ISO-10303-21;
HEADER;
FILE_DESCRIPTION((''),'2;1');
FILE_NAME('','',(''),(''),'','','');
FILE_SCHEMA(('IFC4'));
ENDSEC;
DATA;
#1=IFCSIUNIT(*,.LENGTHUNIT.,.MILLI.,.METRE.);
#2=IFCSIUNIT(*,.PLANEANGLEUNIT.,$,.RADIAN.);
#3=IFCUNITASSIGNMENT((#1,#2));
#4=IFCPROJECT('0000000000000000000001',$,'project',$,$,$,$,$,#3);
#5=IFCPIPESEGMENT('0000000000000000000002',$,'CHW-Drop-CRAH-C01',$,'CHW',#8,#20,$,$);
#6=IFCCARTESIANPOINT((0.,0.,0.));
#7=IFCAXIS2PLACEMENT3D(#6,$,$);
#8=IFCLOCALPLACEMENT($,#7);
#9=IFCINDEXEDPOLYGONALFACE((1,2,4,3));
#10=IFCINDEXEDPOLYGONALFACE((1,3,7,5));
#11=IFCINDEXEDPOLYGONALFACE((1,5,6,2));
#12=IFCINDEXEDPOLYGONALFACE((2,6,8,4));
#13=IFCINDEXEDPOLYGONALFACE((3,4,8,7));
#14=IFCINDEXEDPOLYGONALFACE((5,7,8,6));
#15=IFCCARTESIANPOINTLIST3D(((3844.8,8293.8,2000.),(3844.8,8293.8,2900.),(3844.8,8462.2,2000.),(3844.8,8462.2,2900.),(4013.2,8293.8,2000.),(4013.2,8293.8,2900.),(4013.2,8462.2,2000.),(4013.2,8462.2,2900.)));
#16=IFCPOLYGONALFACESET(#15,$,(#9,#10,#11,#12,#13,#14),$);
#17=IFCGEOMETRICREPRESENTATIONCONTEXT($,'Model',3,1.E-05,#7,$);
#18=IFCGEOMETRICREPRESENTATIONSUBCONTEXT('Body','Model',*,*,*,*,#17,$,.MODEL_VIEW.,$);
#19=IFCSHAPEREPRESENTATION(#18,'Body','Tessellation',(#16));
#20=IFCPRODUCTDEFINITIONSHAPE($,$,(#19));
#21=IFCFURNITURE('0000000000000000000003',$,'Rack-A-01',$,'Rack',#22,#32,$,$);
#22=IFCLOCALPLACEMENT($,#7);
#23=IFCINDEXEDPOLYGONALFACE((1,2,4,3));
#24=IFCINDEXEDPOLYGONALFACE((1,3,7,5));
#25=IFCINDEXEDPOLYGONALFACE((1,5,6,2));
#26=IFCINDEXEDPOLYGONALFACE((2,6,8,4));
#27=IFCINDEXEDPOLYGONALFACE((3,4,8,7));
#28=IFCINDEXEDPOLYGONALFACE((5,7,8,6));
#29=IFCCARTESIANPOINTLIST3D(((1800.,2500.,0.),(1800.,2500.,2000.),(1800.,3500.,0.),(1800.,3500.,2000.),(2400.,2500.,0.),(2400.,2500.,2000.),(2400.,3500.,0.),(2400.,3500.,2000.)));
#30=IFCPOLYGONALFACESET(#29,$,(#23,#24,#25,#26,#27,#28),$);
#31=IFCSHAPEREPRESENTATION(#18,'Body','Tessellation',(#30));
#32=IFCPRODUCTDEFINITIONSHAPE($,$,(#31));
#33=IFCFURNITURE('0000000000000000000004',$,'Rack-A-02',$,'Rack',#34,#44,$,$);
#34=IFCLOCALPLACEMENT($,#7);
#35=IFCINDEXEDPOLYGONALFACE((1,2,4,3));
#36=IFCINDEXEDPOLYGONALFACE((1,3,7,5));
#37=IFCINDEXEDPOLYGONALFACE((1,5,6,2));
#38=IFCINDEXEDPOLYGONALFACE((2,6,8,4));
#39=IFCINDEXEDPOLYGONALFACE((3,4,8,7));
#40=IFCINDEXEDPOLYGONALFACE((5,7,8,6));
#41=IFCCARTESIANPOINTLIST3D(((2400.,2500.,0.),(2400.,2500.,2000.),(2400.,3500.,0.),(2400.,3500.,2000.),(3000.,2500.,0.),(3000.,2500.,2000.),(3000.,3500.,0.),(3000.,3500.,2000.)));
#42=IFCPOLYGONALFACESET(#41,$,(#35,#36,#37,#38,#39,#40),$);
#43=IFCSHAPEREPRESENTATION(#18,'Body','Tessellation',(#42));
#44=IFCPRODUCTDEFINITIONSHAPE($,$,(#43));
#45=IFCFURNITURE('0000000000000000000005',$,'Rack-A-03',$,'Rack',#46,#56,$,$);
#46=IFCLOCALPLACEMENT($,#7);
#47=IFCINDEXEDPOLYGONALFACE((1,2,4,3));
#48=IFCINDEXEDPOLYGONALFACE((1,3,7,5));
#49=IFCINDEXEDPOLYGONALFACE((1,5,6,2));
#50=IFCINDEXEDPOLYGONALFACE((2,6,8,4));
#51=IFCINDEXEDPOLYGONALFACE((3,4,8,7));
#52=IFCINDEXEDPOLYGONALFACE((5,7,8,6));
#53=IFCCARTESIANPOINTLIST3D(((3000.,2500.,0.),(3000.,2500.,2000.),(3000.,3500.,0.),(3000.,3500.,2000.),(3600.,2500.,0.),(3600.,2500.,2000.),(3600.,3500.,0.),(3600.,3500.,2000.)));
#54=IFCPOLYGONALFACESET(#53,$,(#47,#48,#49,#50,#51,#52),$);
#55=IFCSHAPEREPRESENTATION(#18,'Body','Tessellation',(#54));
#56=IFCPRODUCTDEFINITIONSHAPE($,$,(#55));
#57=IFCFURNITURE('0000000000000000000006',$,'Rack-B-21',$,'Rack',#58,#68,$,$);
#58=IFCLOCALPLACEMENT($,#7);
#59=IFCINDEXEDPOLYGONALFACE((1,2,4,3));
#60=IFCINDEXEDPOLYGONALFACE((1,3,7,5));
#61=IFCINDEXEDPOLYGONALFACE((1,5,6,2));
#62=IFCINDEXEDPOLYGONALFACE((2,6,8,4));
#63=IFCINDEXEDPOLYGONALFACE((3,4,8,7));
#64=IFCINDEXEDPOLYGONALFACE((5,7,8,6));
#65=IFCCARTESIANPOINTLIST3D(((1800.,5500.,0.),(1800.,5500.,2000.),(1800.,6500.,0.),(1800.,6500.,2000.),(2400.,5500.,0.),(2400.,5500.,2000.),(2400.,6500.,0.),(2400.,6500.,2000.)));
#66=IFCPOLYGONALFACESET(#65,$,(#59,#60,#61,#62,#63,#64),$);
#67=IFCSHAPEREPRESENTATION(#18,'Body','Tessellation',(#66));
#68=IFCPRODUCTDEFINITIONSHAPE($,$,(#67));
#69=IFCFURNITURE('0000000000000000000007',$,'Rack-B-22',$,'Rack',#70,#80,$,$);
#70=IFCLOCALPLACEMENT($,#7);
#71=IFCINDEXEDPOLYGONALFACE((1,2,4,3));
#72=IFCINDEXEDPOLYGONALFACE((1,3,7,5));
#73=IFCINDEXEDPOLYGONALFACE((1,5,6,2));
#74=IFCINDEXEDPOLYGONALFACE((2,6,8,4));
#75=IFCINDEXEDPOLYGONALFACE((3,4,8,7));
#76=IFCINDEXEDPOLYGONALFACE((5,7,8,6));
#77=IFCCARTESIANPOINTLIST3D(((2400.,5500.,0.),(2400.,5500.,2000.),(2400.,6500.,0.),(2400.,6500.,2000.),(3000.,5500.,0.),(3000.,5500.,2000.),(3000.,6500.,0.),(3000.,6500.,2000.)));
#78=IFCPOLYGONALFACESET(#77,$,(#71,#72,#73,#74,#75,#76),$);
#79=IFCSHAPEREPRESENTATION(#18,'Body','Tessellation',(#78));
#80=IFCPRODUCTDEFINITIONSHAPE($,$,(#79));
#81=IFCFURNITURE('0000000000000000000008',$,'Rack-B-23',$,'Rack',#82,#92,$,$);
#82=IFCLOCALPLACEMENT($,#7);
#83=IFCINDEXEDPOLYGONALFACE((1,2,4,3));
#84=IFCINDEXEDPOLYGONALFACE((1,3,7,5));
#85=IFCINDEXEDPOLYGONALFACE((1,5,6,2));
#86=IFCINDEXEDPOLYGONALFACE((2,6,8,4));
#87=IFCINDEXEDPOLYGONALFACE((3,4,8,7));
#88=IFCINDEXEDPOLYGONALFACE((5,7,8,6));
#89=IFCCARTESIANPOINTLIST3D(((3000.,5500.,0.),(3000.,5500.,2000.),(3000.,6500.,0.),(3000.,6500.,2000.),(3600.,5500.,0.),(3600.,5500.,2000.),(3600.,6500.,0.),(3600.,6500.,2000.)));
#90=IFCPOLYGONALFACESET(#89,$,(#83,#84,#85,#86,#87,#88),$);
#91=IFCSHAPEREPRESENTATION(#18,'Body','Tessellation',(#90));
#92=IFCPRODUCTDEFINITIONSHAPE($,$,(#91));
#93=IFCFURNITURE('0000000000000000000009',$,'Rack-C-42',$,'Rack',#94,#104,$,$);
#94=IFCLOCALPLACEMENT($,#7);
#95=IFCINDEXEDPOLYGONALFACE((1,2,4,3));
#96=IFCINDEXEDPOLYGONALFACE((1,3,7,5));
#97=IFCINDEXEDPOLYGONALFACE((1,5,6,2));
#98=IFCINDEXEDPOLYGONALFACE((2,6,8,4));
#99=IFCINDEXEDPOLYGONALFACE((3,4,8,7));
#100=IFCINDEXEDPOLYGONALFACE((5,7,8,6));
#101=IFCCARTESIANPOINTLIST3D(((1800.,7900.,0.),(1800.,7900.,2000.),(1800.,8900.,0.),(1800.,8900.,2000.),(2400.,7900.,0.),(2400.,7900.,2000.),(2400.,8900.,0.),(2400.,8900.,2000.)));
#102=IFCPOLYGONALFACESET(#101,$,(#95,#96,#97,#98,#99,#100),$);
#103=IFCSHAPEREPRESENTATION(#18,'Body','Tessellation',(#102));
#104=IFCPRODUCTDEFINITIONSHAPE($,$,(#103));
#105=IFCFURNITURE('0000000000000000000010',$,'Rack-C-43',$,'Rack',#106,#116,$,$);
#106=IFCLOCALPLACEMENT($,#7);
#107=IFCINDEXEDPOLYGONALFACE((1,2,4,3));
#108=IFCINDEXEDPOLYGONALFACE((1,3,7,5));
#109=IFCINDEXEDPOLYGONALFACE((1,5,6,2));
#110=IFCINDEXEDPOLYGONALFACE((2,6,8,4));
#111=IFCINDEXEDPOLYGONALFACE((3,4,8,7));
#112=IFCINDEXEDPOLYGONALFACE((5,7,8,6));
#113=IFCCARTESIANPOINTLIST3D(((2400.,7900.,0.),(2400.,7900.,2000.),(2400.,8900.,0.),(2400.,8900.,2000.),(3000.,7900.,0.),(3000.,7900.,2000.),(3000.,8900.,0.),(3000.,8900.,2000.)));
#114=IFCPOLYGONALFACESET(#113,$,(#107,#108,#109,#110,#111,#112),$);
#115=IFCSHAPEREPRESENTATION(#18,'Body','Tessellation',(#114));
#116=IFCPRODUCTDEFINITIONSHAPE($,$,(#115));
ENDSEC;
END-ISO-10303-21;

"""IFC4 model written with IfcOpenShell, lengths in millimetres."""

from ifc_helpers import new_model, si_unit, frame, origin, place, context, subcontext, project, rectangle, extrude, element, save


model = new_model("IFC4")

# Units and contexts
model_context = context("Model", 3, precision=1e-05, world=origin())
body_context = subcontext(model_context, "Body", "Model", "MODEL_VIEW")
ifc_project = project(units=[si_unit("LENGTHUNIT", "METRE", prefix="MILLI"), si_unit("PLANEANGLEUNIT", "RADIAN")])

# Pipe segment
pipe_segment_1_placement = place(None, frame((3929.0, 8378.0, 2000.0)))
element("IfcPipeSegment", 1, at=pipe_segment_1_placement, Name="CHW-Drop-CRAH-C01", ObjectType="CHW", context=body_context, shape_type="SweptSolid", body=[
    extrude(rectangle(XDim=168.3, YDim=168.3), None, (0.0, 0.0, 1.0), 900.0),
])

# Furniture
for number, where, name in (
    (2, (2100.0, 3000.0, 0.0), "Rack-A-01"),
    (3, (2700.0, 3000.0, 0.0), "Rack-A-02"),
    (4, (3300.0, 3000.0, 0.0), "Rack-A-03"),
    (5, (2100.0, 6000.0, 0.0), "Rack-B-21"),
    (6, (2700.0, 6000.0, 0.0), "Rack-B-22"),
    (7, (3300.0, 6000.0, 0.0), "Rack-B-23"),
    (8, (2100.0, 8400.0, 0.0), "Rack-C-42"),
    (9, (2700.0, 8400.0, 0.0), "Rack-C-43"),
):
    element("IfcFurniture", number, at=place(None, frame(where)), Name=name, ObjectType="Rack", context=body_context, shape_type="SweptSolid", body=[
        extrude(rectangle(XDim=600.0, YDim=1000.0), None, (0.0, 0.0, 1.0), 2000.0),
    ])

save(model, "model.ifc")
